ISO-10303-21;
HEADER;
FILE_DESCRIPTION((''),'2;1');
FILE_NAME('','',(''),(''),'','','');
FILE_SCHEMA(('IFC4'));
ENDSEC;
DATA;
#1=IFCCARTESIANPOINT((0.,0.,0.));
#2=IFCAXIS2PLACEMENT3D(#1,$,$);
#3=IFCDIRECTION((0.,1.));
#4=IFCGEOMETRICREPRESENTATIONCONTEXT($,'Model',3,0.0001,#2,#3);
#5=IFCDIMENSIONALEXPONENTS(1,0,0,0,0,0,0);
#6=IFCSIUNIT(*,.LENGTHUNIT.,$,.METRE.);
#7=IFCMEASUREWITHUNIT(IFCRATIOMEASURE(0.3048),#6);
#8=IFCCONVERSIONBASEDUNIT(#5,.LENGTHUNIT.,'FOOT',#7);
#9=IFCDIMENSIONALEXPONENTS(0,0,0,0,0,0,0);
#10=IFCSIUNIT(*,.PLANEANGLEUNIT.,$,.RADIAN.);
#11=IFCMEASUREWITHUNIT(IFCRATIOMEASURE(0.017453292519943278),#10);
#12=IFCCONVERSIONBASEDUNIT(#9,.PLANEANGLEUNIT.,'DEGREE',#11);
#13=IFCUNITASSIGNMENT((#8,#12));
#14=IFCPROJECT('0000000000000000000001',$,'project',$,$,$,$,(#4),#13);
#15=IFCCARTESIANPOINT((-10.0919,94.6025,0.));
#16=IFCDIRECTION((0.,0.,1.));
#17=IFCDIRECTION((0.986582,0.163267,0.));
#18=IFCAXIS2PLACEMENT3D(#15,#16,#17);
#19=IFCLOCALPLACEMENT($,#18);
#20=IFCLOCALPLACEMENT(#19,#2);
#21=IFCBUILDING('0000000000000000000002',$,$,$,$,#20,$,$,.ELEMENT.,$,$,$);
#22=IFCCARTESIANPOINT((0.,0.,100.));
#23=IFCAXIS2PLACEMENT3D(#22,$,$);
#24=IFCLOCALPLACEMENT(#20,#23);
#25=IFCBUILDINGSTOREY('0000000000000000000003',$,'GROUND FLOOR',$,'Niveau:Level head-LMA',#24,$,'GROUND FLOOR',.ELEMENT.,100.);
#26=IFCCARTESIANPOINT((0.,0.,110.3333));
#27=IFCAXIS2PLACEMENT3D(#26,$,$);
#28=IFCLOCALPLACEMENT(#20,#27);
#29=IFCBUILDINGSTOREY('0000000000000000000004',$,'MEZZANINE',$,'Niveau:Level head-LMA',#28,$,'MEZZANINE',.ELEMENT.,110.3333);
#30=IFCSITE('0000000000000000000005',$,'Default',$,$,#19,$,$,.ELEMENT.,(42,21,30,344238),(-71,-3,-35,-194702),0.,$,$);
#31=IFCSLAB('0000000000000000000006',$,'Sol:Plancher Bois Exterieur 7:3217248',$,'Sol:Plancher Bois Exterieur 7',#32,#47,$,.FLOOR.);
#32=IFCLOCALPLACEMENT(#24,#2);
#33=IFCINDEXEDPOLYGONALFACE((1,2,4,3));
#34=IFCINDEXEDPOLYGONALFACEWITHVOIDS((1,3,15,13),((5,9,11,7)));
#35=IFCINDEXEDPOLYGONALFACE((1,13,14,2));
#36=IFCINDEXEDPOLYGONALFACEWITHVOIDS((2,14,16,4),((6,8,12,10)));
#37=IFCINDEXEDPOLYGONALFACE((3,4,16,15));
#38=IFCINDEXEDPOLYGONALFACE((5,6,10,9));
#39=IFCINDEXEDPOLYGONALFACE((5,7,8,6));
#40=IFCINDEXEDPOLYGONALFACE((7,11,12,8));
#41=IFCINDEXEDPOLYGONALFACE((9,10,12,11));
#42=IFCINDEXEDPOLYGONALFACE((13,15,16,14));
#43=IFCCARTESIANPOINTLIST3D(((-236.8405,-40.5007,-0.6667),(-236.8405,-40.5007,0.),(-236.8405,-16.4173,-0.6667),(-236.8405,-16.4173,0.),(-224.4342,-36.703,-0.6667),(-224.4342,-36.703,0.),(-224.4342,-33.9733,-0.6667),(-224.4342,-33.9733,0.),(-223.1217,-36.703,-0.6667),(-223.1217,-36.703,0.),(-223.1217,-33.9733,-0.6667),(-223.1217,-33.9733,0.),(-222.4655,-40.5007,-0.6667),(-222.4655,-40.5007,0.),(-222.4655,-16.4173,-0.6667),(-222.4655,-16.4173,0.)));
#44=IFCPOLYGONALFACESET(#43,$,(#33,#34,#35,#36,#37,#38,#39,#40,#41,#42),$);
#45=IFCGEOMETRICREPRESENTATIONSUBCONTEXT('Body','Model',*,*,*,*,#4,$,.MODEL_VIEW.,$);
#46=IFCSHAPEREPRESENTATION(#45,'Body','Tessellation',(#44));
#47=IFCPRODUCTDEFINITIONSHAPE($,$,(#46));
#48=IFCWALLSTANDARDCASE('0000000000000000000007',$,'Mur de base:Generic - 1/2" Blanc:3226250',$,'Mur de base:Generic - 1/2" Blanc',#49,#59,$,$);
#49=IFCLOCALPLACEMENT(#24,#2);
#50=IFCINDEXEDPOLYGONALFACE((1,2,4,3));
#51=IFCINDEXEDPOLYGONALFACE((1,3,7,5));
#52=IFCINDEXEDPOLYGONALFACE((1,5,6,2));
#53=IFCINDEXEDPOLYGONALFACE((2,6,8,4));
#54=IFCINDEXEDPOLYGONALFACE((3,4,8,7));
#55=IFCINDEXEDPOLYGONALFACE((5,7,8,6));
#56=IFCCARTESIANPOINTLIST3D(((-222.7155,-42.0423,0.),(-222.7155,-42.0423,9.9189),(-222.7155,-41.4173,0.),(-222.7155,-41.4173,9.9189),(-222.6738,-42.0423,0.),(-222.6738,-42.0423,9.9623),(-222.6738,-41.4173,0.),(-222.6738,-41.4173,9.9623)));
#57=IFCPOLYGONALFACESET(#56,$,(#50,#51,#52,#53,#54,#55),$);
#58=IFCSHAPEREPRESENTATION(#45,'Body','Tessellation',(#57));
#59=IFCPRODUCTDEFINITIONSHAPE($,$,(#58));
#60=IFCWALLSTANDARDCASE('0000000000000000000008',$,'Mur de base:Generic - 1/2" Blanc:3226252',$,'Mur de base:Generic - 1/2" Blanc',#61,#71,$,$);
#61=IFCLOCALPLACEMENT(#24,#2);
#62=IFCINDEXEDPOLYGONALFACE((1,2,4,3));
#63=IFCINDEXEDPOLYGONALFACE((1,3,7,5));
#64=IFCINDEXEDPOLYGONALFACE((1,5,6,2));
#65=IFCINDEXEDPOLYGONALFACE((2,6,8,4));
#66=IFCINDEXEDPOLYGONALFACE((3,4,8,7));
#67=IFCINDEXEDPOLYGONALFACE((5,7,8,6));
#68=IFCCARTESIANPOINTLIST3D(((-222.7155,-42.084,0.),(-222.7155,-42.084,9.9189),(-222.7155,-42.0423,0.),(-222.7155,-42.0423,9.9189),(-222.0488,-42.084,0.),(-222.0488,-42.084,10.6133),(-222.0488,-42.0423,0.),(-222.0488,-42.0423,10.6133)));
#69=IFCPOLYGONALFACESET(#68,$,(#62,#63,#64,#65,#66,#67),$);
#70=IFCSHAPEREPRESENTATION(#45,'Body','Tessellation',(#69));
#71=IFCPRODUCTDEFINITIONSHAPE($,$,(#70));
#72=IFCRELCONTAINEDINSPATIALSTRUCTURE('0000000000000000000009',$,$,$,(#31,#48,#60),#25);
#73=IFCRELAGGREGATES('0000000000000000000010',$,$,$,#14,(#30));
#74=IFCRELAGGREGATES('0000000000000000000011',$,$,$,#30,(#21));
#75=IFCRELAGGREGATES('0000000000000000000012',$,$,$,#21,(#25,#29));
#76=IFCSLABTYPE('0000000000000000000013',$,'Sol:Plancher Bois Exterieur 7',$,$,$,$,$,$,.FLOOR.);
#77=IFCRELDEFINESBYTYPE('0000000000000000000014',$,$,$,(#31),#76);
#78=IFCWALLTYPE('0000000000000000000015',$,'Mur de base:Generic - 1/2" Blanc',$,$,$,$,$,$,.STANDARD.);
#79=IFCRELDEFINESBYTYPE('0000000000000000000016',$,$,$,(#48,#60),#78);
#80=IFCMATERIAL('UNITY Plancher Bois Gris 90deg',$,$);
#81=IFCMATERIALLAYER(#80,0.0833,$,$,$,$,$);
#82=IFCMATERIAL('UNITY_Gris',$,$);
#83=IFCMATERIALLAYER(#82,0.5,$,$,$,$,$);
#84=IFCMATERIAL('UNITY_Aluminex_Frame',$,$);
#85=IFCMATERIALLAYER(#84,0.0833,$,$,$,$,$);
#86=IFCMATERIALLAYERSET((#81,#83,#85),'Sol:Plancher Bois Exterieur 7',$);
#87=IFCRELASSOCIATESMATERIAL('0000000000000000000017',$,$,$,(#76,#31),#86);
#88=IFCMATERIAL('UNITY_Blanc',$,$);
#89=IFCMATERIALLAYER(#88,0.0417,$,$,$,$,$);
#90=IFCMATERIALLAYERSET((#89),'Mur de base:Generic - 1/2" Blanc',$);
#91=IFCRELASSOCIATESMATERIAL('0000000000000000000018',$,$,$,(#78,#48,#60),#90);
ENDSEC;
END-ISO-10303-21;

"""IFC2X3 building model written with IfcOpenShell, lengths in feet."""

from ifc_helpers import new_model, entity, si_unit, converted_unit, direction, frame, frame_2d, origin, origin_2d_with_axis, place, context, subcontext, project, spatial, polyline, rectangle, extrude, clip, bounded_halfspace, material, layer, layer_set, layer_usage, type_object, element, save


model = new_model("IFC2X3")

# Units and contexts
model_context = context("Model", 3, precision=0.0001, world=origin(), true_north=direction((0.0, 1.0)))
body_context = subcontext(model_context, "Body", "Model", "MODEL_VIEW")
ifc_project = project(units=[converted_unit("LENGTHUNIT", "FOOT", entity("IfcRatioMeasure", 0.3048), si_unit("LENGTHUNIT", "METRE"), dimensions=[1, 0, 0, 0, 0, 0, 0]), converted_unit("PLANEANGLEUNIT", "DEGREE", entity("IfcRatioMeasure", 0.017453292519943278), si_unit("PLANEANGLEUNIT", "RADIAN"), dimensions=[0, 0, 0, 0, 0, 0, 0])], contexts=[model_context])

# Site, building, storey
site_placement = place(None, frame((-10.0919, 94.6025, 0.0), z_axis=(0.0, 0.0, 1.0), x_axis=(0.986582, 0.163267, 0.0)))
site = spatial("IfcSite", under=ifc_project, at=site_placement, Name="Default", CompositionType="ELEMENT", RefLatitude=(42, 21, 30, 344238), RefLongitude=(-71, -3, -35, -194702), RefElevation=0.0)
building_placement = place(site_placement, origin())
building = spatial("IfcBuilding", under=site, at=building_placement, CompositionType="ELEMENT")
storey_1_placement = place(building_placement, frame((0.0, 0.0, 100.0)))
storey_1 = spatial("IfcBuildingStorey", under=building, at=storey_1_placement, Name="GROUND FLOOR", ObjectType="Niveau:Level head-LMA", LongName="GROUND FLOOR", CompositionType="ELEMENT", Elevation=100.0)

# Slab, opening
ifc_material_1 = material(Name="UNITY Plancher Bois Gris 90deg")
ifc_layer_1 = layer(ifc_material_1, 0.0833)
ifc_material_2 = material(Name="UNITY_Gris")
ifc_layer_2 = layer(ifc_material_2, 0.5)
ifc_material_3 = material(Name="UNITY_Aluminex_Frame")
ifc_layer_3 = layer(ifc_material_3, 0.0833)
ifc_layer_set_1 = layer_set([ifc_layer_1, ifc_layer_2, ifc_layer_3], Name="Sol:Plancher Bois Exterieur 7")
ifc_layer_usage_1 = layer_usage(ifc_layer_set_1, "AXIS3", "POSITIVE", 0.0)
slab_type = type_object("IfcSlabType", Name="Sol:Plancher Bois Exterieur 7", PredefinedType="FLOOR", material=ifc_layer_set_1)
slab_placement = place(storey_1_placement, frame((-236.8405, -40.5007, -0.6667)))
slab = element("IfcSlab", 1, at=slab_placement, inside=storey_1, type_object=slab_type, material=ifc_layer_usage_1, Name="Sol:Plancher Bois Exterieur 7:3217248", ObjectType="Sol:Plancher Bois Exterieur 7", PredefinedType="FLOOR", context=body_context, shape_type="SweptSolid", body=[
    extrude(rectangle(XDim=24.0833, YDim=14.375, at=frame_2d((0.0, 0.0), x_axis=(0.0, 1.0))), frame((7.1875, 12.0417, 0.6667), z_axis=(0.0, 0.0, -1.0), x_axis=(-1.0, 0.0, 0.0)), (0.0, 0.0, 1.0), 0.6667),
])
opening_1_placement = place(slab_placement, frame((13.0625, 5.1625, 0.6667)))
element("IfcOpeningElement", 2, at=opening_1_placement, cuts=slab, ObjectType="Opening", context=body_context, shape_type="SweptSolid", body=[
    extrude(rectangle(XDim=2.7297, YDim=1.3125, at=origin_2d_with_axis()), frame((0.0, 0.0, 0.0), z_axis=(0.0, 0.0, -1.0), x_axis=(0.0, 1.0, 0.0)), (0.0, 0.0, 1.0), 0.6667),
])

# Walls
ifc_material_4 = material(Name="UNITY_Blanc")
ifc_layer_4 = layer(ifc_material_4, 0.0417)
ifc_layer_set_2 = layer_set([ifc_layer_4], Name="Mur de base:Generic - 1/2\" Blanc")
ifc_layer_usage_2 = layer_usage(ifc_layer_set_2, "AXIS2", "POSITIVE", -0.0208)
wall_type_1 = type_object("IfcWallType", Name="Mur de base:Generic - 1/2\" Blanc", PredefinedType="STANDARD", material=ifc_layer_set_2)
wall_1_placement = place(storey_1_placement, frame((-222.6947, -41.4173, 0.0), z_axis=(0.0, 0.0, 1.0), x_axis=(0.0, -1.0, 0.0)))
element("IfcWallStandardCase", 3, at=wall_1_placement, inside=storey_1, type_object=wall_type_1, material=ifc_layer_usage_2, Name="Mur de base:Generic - 1/2\" Blanc:3226250", ObjectType="Mur de base:Generic - 1/2\" Blanc", context=body_context, shape_type="Clipping", body=[
    clip(extrude(rectangle(XDim=0.625, YDim=0.0417, at=frame_2d((0.3125, 0.0), x_axis=(-1.0, 0.0))), origin(), (0.0, 0.0, 1.0), 9.9623), bounded_halfspace(frame((0.0, -0.0208, 9.9189), z_axis=(0.0, -0.721387, 0.692532), x_axis=(1.0, 0.0, 0.0)), False, frame((0.0, -0.0208, 9.9189)), polyline([(0.0, 0.0), (0.625, 0.0), (0.625, 0.0417), (0.0, 0.0417), (0.0, 0.0)]))),
])
ifc_layer_usage_3 = layer_usage(ifc_layer_set_2, "AXIS2", "POSITIVE", -0.0208)
wall_2_placement = place(storey_1_placement, frame((-222.7155, -42.0632, 0.0)))
element("IfcWallStandardCase", 4, at=wall_2_placement, inside=storey_1, type_object=wall_type_1, material=ifc_layer_usage_3, Name="Mur de base:Generic - 1/2\" Blanc:3226252", ObjectType="Mur de base:Generic - 1/2\" Blanc", context=body_context, shape_type="Clipping", body=[
    clip(extrude(rectangle(XDim=0.6667, YDim=0.0417, at=frame_2d((0.3333, 0.0), x_axis=(-1.0, 0.0))), origin(), (0.0, 0.0, 1.0), 10.6133), bounded_halfspace(frame((0.0, -0.0208, 9.9189), z_axis=(-0.721387, 0.0, 0.692532), x_axis=(0.0, -1.0, 0.0)), False, frame((0.0, -0.0208, 9.9189)), polyline([(0.0, 0.0), (0.6667, 0.0), (0.6667, 0.0417), (0.0417, 0.0417), (0.0, 0.0417), (0.0, 0.0)]))),
])

# Shared definitions
storey_2_placement = place(building_placement, frame((0.0, 0.0, 110.3333)))
storey_2 = spatial("IfcBuildingStorey", under=building, at=storey_2_placement, Name="MEZZANINE", ObjectType="Niveau:Level head-LMA", LongName="MEZZANINE", CompositionType="ELEMENT", Elevation=110.3333)

save(model, "model.ifc")
